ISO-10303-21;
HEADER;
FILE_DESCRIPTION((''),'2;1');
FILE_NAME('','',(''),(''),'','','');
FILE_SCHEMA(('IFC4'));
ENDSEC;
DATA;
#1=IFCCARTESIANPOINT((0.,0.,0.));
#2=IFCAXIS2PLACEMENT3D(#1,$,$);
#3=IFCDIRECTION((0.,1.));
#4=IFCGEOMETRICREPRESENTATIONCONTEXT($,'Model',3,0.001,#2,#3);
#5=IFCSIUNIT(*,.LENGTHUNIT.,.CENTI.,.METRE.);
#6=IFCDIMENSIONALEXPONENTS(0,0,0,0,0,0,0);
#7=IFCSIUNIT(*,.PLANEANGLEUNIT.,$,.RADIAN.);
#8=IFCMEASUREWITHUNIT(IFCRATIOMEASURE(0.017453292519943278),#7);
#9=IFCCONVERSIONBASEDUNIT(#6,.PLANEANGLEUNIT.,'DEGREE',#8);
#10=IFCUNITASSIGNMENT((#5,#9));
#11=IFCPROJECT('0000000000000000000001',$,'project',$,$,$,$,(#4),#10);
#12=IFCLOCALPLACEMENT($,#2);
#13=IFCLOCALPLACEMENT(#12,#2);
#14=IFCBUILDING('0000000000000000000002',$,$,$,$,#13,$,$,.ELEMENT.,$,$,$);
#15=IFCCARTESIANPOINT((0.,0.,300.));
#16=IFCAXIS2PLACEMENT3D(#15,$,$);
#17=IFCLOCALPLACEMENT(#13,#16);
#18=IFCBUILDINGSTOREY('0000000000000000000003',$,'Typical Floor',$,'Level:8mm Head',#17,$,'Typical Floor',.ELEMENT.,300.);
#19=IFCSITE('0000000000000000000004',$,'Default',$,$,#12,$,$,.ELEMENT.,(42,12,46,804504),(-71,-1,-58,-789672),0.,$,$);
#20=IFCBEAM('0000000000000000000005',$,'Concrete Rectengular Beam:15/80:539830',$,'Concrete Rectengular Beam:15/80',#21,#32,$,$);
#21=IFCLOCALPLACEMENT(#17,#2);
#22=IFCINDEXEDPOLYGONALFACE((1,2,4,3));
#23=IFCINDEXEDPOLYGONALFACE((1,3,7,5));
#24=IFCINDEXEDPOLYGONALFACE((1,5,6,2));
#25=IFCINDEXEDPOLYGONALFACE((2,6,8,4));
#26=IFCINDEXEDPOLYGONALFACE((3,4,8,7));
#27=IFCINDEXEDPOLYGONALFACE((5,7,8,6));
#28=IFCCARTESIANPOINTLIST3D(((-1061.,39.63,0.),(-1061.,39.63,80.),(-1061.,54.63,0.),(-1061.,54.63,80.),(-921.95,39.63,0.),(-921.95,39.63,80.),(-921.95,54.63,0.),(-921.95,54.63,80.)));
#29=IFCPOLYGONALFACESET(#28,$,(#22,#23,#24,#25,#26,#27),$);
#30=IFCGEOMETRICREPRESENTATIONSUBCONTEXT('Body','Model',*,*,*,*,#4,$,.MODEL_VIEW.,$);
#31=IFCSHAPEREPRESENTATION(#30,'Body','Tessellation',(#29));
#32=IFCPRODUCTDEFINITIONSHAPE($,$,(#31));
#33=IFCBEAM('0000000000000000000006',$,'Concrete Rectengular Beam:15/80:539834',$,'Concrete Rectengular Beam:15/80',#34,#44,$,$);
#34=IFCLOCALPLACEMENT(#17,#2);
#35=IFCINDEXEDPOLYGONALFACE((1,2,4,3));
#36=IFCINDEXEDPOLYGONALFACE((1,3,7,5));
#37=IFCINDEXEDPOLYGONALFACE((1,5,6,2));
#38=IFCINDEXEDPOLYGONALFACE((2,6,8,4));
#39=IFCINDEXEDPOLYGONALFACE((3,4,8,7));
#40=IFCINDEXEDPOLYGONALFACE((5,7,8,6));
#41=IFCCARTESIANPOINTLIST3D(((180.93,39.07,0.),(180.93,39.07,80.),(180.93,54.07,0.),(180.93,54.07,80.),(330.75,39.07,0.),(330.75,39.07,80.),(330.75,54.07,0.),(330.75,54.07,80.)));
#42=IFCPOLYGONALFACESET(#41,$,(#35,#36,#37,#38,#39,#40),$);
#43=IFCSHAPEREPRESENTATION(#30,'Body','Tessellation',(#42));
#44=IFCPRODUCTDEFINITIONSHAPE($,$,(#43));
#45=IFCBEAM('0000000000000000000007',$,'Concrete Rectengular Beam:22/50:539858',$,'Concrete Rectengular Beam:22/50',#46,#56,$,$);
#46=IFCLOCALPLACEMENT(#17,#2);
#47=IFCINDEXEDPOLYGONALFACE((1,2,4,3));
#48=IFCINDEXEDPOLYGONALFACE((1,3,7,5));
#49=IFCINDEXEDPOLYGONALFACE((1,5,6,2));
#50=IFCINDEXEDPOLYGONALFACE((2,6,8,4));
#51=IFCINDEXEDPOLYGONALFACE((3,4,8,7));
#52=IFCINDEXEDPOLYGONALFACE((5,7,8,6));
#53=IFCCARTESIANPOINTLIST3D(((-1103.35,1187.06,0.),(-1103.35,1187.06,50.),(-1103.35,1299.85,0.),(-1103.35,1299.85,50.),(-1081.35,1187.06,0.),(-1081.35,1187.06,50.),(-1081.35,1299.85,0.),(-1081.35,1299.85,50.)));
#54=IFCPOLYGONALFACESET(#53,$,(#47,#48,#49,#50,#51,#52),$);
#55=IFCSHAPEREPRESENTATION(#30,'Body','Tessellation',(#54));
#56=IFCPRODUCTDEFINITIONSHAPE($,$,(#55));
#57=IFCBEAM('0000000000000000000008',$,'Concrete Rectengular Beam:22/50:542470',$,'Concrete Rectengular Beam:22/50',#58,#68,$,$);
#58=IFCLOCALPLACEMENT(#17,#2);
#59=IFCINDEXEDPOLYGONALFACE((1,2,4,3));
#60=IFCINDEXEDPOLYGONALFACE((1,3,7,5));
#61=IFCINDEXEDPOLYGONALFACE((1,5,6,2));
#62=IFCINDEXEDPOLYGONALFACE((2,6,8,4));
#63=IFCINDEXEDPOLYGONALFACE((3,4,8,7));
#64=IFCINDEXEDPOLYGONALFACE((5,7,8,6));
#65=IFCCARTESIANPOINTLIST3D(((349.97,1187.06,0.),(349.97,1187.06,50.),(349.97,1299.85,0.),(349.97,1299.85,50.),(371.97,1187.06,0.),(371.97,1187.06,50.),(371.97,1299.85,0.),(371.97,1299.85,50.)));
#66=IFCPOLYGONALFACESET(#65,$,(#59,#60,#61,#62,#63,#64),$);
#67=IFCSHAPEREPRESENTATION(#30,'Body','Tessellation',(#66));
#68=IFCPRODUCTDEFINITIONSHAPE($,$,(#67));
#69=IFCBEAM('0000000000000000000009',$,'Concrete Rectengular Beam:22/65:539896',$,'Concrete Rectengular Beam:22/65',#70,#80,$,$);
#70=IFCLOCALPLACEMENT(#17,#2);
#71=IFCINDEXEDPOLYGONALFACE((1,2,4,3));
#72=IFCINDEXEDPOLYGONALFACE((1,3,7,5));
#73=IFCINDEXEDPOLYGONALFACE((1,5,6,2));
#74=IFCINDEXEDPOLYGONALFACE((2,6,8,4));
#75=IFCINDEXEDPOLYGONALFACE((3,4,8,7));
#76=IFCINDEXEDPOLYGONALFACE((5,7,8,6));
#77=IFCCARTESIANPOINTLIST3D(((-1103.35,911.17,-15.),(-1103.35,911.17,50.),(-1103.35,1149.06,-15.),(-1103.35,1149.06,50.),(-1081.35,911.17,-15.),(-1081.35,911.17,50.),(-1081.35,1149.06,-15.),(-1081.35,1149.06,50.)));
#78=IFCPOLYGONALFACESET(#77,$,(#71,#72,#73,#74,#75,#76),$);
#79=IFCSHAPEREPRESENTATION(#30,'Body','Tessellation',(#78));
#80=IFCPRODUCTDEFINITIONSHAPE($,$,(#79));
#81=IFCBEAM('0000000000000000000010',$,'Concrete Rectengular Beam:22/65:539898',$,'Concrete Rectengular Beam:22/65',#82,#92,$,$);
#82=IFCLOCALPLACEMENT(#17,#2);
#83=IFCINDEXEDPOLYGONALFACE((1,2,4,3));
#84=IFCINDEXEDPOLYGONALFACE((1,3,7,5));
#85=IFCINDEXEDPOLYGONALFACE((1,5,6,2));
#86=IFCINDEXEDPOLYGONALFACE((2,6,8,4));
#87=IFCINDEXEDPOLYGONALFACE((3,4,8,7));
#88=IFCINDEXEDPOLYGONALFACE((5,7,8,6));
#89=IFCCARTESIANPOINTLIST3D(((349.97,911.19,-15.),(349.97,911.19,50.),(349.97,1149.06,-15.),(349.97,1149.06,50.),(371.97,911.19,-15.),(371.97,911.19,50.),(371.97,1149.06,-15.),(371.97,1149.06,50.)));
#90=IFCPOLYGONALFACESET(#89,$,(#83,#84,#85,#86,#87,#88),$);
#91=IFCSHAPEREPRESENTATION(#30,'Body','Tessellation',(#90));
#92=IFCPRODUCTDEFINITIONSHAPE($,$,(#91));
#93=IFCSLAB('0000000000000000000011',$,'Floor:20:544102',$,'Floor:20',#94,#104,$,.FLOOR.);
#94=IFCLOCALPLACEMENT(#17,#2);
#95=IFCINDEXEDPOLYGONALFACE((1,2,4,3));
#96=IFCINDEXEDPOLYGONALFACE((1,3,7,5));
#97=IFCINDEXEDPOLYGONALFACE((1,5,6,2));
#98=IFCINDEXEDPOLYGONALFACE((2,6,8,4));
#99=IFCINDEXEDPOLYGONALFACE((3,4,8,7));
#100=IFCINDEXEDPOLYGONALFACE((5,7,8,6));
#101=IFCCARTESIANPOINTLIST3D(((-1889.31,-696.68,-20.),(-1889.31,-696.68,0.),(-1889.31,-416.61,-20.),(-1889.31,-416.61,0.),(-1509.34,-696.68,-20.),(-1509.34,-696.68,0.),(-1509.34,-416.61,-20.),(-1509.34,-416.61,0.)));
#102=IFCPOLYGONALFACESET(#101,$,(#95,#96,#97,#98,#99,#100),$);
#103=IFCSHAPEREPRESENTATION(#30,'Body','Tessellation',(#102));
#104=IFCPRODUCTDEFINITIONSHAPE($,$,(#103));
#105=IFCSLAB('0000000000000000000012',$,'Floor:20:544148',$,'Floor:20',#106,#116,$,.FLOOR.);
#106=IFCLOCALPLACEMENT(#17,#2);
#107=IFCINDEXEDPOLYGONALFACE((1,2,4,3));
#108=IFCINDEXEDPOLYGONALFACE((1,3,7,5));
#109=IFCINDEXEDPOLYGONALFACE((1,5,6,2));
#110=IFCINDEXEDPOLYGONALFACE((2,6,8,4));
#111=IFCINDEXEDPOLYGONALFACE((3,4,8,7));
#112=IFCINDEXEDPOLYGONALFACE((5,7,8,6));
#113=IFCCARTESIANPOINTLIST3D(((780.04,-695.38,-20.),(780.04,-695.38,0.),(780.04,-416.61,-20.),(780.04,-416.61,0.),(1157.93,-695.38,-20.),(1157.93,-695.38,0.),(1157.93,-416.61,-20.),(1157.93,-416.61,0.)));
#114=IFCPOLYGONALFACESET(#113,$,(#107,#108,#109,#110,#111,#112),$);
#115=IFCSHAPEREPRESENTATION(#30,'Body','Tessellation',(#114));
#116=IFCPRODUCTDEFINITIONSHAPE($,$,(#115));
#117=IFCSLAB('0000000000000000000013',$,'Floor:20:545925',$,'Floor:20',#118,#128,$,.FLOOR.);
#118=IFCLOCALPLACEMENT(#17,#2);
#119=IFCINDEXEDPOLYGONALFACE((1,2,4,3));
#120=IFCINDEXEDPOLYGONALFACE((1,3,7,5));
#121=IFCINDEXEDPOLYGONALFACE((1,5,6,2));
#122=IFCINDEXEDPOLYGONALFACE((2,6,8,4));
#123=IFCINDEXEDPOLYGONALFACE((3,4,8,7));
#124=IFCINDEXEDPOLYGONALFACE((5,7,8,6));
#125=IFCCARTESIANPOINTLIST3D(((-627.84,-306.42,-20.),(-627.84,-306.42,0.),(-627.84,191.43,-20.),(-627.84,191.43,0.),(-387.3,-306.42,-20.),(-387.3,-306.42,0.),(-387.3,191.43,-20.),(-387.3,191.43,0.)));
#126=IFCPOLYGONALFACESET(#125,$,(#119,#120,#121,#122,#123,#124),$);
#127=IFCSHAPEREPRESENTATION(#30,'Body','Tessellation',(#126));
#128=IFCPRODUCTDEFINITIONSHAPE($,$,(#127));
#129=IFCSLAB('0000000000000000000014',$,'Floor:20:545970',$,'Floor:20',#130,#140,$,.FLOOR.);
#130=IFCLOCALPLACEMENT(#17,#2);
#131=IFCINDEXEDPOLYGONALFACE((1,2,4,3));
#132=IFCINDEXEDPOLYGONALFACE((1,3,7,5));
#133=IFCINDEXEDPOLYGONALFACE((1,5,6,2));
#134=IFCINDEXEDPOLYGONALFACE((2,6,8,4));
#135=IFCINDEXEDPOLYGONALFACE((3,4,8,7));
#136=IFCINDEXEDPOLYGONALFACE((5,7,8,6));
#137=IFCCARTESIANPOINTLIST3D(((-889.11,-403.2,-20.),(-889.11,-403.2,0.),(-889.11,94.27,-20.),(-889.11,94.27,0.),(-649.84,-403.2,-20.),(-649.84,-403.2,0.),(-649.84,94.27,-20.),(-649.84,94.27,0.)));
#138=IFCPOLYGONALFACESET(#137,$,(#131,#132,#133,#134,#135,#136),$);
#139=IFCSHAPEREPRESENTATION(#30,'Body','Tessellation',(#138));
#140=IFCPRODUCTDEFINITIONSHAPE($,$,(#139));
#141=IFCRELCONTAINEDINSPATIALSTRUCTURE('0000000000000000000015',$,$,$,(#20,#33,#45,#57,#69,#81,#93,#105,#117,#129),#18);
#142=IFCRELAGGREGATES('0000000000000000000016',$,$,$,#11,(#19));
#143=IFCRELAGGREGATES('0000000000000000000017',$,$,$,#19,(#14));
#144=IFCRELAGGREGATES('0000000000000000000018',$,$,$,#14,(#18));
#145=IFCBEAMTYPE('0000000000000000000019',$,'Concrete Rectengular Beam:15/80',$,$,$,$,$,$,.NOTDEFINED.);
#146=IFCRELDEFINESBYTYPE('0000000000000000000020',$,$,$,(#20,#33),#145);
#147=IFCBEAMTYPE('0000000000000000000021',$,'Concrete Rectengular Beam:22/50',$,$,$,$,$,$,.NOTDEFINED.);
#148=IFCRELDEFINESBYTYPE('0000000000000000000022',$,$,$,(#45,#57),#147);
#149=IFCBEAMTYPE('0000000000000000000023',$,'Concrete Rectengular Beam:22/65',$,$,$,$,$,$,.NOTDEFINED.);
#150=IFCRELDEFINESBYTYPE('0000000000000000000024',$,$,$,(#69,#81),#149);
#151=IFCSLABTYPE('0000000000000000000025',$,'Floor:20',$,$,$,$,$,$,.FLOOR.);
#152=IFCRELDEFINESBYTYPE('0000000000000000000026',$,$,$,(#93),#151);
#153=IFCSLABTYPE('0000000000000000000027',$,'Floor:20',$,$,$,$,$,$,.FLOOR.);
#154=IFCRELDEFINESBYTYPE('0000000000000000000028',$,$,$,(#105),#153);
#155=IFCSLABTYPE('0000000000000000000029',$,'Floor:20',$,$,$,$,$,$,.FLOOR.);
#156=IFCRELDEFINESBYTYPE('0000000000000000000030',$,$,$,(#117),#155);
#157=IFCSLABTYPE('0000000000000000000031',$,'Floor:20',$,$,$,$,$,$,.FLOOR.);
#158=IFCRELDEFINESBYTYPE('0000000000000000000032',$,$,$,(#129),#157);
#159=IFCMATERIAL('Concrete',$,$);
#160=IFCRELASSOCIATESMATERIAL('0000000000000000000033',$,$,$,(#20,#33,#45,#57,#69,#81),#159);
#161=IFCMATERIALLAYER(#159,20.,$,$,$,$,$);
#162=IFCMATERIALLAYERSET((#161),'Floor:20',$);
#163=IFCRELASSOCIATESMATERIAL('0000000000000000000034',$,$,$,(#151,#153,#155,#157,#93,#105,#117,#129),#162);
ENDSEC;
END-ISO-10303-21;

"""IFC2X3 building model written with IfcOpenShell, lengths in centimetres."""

from ifc_helpers import new_model, entity, si_unit, converted_unit, direction, frame, frame_2d, origin, place, context, subcontext, project, spatial, rectangle, extrude, material, layer, layer_set, layer_usage, type_object, element, save


model = new_model("IFC2X3")

# Units and contexts
model_context = context("Model", 3, precision=0.001, world=origin(), true_north=direction((0.0, 1.0)))
body_context = subcontext(model_context, "Body", "Model", "MODEL_VIEW")
ifc_project = project(units=[si_unit("LENGTHUNIT", "METRE", prefix="CENTI"), converted_unit("PLANEANGLEUNIT", "DEGREE", entity("IfcRatioMeasure", 0.017453292519943278), si_unit("PLANEANGLEUNIT", "RADIAN"), dimensions=[0, 0, 0, 0, 0, 0, 0])], contexts=[model_context])

# Site, building, storey
site_placement = place(None, origin())
site = spatial("IfcSite", under=ifc_project, at=site_placement, Name="Default", CompositionType="ELEMENT", RefLatitude=(42, 12, 46, 804504), RefLongitude=(-71, -1, -58, -789672), RefElevation=0.0)
building_placement = place(site_placement, origin())
building = spatial("IfcBuilding", under=site, at=building_placement, CompositionType="ELEMENT")
storey_placement = place(building_placement, frame((0.0, 0.0, 300.0)))
storey = spatial("IfcBuildingStorey", under=building, at=storey_placement, Name="Typical Floor", ObjectType="Level:8mm Head", LongName="Typical Floor", CompositionType="ELEMENT", Elevation=300.0)

# Beams
ifc_material = material(Name="Concrete")
beam_type_1 = type_object("IfcBeamType", Name="Concrete Rectengular Beam:15/80", PredefinedType="NOTDEFINED")
beam_1_placement = place(storey_placement, frame((-1061.0, 47.13, 0.0)))
element("IfcBeam", 1, at=beam_1_placement, inside=storey, type_object=beam_type_1, material=ifc_material, Name="Concrete Rectengular Beam:15/80:539830", ObjectType="Concrete Rectengular Beam:15/80", context=body_context, shape_type="SweptSolid", body=[
    extrude(rectangle(XDim=80.0, YDim=15.0, at=frame_2d((0.0, 0.0), x_axis=(1.0, 0.0))), frame((0.0, 0.0, 40.0), z_axis=(1.0, 0.0, 0.0), x_axis=(0.0, 0.0, -1.0)), (0.0, 0.0, 1.0), 139.05),
])
beam_2_placement = place(storey_placement, frame((330.75, 46.57, 0.0), z_axis=(0.0, 0.0, 1.0), x_axis=(-1.0, 0.0, 0.0)))
element("IfcBeam", 2, at=beam_2_placement, inside=storey, type_object=beam_type_1, material=ifc_material, Name="Concrete Rectengular Beam:15/80:539834", ObjectType="Concrete Rectengular Beam:15/80", context=body_context, shape_type="SweptSolid", body=[
    extrude(rectangle(XDim=80.0, YDim=15.0, at=frame_2d((0.0, 0.0), x_axis=(1.0, 0.0))), frame((0.0, 0.0, 40.0), z_axis=(1.0, 0.0, 0.0), x_axis=(0.0, 0.0, -1.0)), (0.0, 0.0, 1.0), 149.82),
])
beam_type_2 = type_object("IfcBeamType", Name="Concrete Rectengular Beam:22/50", PredefinedType="NOTDEFINED")
beam_3_placement = place(storey_placement, frame((-1092.35, 1187.06, 0.0), z_axis=(0.0, 0.0, 1.0), x_axis=(0.0, 1.0, 0.0)))
element("IfcBeam", 3, at=beam_3_placement, inside=storey, type_object=beam_type_2, material=ifc_material, Name="Concrete Rectengular Beam:22/50:539858", ObjectType="Concrete Rectengular Beam:22/50", context=body_context, shape_type="SweptSolid", body=[
    extrude(rectangle(XDim=50.0, YDim=22.0, at=frame_2d((0.0, 0.0), x_axis=(1.0, 0.0))), frame((0.0, 0.0, 25.0), z_axis=(1.0, 0.0, 0.0), x_axis=(0.0, 0.0, -1.0)), (0.0, 0.0, 1.0), 112.79),
])
beam_4_placement = place(storey_placement, frame((360.97, 1187.06, 0.0), z_axis=(0.0, 0.0, 1.0), x_axis=(0.0, 1.0, 0.0)))
element("IfcBeam", 4, at=beam_4_placement, inside=storey, type_object=beam_type_2, material=ifc_material, Name="Concrete Rectengular Beam:22/50:542470", ObjectType="Concrete Rectengular Beam:22/50", context=body_context, shape_type="SweptSolid", body=[
    extrude(rectangle(XDim=50.0, YDim=22.0, at=frame_2d((0.0, 0.0), x_axis=(1.0, 0.0))), frame((0.0, 0.0, 25.0), z_axis=(1.0, 0.0, 0.0), x_axis=(0.0, 0.0, -1.0)), (0.0, 0.0, 1.0), 112.79),
])
beam_type_3 = type_object("IfcBeamType", Name="Concrete Rectengular Beam:22/65", PredefinedType="NOTDEFINED")
beam_5_placement = place(storey_placement, frame((-1103.35, 911.17, 0.0), z_axis=(0.0, 0.0, 1.0), x_axis=(0.0, 1.0, 0.0)))
element("IfcBeam", 5, at=beam_5_placement, inside=storey, type_object=beam_type_3, material=ifc_material, Name="Concrete Rectengular Beam:22/65:539896", ObjectType="Concrete Rectengular Beam:22/65", context=body_context, shape_type="SweptSolid", body=[
    extrude(rectangle(XDim=65.0, YDim=22.0, at=frame_2d((0.0, 0.0), x_axis=(1.0, 0.0))), frame((0.0, -11.0, 17.5), z_axis=(1.0, 0.0, 0.0), x_axis=(0.0, 0.0, -1.0)), (0.0, 0.0, 1.0), 237.89),
])
beam_6_placement = place(storey_placement, frame((371.97, 1149.06, 0.0), z_axis=(0.0, 0.0, 1.0), x_axis=(0.0, -1.0, 0.0)))
element("IfcBeam", 6, at=beam_6_placement, inside=storey, type_object=beam_type_3, material=ifc_material, Name="Concrete Rectengular Beam:22/65:539898", ObjectType="Concrete Rectengular Beam:22/65", context=body_context, shape_type="SweptSolid", body=[
    extrude(rectangle(XDim=65.0, YDim=22.0, at=frame_2d((0.0, 0.0), x_axis=(1.0, 0.0))), frame((0.0, -11.0, 17.5), z_axis=(1.0, 0.0, 0.0), x_axis=(0.0, 0.0, -1.0)), (0.0, 0.0, 1.0), 237.86),
])

# Slabs
ifc_layer = layer(ifc_material, 20.0)
ifc_layer_set = layer_set([ifc_layer], Name="Floor:20")
ifc_layer_usage_1 = layer_usage(ifc_layer_set, "AXIS3", "POSITIVE", 0.0)
slab_type_1 = type_object("IfcSlabType", Name="Floor:20", PredefinedType="FLOOR", material=ifc_layer_set)
slab_1_placement = place(storey_placement, origin())
element("IfcSlab", 7, at=slab_1_placement, inside=storey, type_object=slab_type_1, material=ifc_layer_usage_1, Name="Floor:20:544102", ObjectType="Floor:20", PredefinedType="FLOOR", context=body_context, shape_type="SweptSolid", body=[
    extrude(rectangle(XDim=280.07, YDim=379.97, at=frame_2d((0.0, 0.0), x_axis=(1.0, 0.0))), frame((-1699.32, -556.65, 0.0), z_axis=(0.0, 0.0, -1.0), x_axis=(0.0, 1.0, 0.0)), (0.0, 0.0, 1.0), 20.0),
])
ifc_layer_usage_2 = layer_usage(ifc_layer_set, "AXIS3", "POSITIVE", 0.0)
slab_type_2 = type_object("IfcSlabType", Name="Floor:20", PredefinedType="FLOOR", material=ifc_layer_set)
slab_2_placement = place(storey_placement, origin())
element("IfcSlab", 8, at=slab_2_placement, inside=storey, type_object=slab_type_2, material=ifc_layer_usage_2, Name="Floor:20:544148", ObjectType="Floor:20", PredefinedType="FLOOR", context=body_context, shape_type="SweptSolid", body=[
    extrude(rectangle(XDim=278.76, YDim=377.89, at=frame_2d((0.0, 0.0), x_axis=(1.0, 0.0))), frame((968.99, -555.99, 0.0), z_axis=(0.0, 0.0, -1.0), x_axis=(0.0, 1.0, 0.0)), (0.0, 0.0, 1.0), 20.0),
])
ifc_layer_usage_3 = layer_usage(ifc_layer_set, "AXIS3", "POSITIVE", 0.0)
slab_type_3 = type_object("IfcSlabType", Name="Floor:20", PredefinedType="FLOOR", material=ifc_layer_set)
slab_3_placement = place(storey_placement, origin())
element("IfcSlab", 9, at=slab_3_placement, inside=storey, type_object=slab_type_3, material=ifc_layer_usage_3, Name="Floor:20:545925", ObjectType="Floor:20", PredefinedType="FLOOR", context=body_context, shape_type="SweptSolid", body=[
    extrude(rectangle(XDim=497.85, YDim=240.54, at=frame_2d((0.0, 0.0), x_axis=(1.0, 0.0))), frame((-507.57, -57.49, 0.0), z_axis=(0.0, 0.0, -1.0), x_axis=(0.0, 1.0, 0.0)), (0.0, 0.0, 1.0), 20.0),
])
ifc_layer_usage_4 = layer_usage(ifc_layer_set, "AXIS3", "POSITIVE", 0.0)
slab_type_4 = type_object("IfcSlabType", Name="Floor:20", PredefinedType="FLOOR", material=ifc_layer_set)
slab_4_placement = place(storey_placement, origin())
element("IfcSlab", 10, at=slab_4_placement, inside=storey, type_object=slab_type_4, material=ifc_layer_usage_4, Name="Floor:20:545970", ObjectType="Floor:20", PredefinedType="FLOOR", context=body_context, shape_type="SweptSolid", body=[
    extrude(rectangle(XDim=497.47, YDim=239.27, at=frame_2d((0.0, 0.0), x_axis=(1.0, 0.0))), frame((-769.48, -154.46, 0.0), z_axis=(0.0, 0.0, -1.0), x_axis=(0.0, 1.0, 0.0)), (0.0, 0.0, 1.0), 20.0),
])

save(model, "model.ifc")
